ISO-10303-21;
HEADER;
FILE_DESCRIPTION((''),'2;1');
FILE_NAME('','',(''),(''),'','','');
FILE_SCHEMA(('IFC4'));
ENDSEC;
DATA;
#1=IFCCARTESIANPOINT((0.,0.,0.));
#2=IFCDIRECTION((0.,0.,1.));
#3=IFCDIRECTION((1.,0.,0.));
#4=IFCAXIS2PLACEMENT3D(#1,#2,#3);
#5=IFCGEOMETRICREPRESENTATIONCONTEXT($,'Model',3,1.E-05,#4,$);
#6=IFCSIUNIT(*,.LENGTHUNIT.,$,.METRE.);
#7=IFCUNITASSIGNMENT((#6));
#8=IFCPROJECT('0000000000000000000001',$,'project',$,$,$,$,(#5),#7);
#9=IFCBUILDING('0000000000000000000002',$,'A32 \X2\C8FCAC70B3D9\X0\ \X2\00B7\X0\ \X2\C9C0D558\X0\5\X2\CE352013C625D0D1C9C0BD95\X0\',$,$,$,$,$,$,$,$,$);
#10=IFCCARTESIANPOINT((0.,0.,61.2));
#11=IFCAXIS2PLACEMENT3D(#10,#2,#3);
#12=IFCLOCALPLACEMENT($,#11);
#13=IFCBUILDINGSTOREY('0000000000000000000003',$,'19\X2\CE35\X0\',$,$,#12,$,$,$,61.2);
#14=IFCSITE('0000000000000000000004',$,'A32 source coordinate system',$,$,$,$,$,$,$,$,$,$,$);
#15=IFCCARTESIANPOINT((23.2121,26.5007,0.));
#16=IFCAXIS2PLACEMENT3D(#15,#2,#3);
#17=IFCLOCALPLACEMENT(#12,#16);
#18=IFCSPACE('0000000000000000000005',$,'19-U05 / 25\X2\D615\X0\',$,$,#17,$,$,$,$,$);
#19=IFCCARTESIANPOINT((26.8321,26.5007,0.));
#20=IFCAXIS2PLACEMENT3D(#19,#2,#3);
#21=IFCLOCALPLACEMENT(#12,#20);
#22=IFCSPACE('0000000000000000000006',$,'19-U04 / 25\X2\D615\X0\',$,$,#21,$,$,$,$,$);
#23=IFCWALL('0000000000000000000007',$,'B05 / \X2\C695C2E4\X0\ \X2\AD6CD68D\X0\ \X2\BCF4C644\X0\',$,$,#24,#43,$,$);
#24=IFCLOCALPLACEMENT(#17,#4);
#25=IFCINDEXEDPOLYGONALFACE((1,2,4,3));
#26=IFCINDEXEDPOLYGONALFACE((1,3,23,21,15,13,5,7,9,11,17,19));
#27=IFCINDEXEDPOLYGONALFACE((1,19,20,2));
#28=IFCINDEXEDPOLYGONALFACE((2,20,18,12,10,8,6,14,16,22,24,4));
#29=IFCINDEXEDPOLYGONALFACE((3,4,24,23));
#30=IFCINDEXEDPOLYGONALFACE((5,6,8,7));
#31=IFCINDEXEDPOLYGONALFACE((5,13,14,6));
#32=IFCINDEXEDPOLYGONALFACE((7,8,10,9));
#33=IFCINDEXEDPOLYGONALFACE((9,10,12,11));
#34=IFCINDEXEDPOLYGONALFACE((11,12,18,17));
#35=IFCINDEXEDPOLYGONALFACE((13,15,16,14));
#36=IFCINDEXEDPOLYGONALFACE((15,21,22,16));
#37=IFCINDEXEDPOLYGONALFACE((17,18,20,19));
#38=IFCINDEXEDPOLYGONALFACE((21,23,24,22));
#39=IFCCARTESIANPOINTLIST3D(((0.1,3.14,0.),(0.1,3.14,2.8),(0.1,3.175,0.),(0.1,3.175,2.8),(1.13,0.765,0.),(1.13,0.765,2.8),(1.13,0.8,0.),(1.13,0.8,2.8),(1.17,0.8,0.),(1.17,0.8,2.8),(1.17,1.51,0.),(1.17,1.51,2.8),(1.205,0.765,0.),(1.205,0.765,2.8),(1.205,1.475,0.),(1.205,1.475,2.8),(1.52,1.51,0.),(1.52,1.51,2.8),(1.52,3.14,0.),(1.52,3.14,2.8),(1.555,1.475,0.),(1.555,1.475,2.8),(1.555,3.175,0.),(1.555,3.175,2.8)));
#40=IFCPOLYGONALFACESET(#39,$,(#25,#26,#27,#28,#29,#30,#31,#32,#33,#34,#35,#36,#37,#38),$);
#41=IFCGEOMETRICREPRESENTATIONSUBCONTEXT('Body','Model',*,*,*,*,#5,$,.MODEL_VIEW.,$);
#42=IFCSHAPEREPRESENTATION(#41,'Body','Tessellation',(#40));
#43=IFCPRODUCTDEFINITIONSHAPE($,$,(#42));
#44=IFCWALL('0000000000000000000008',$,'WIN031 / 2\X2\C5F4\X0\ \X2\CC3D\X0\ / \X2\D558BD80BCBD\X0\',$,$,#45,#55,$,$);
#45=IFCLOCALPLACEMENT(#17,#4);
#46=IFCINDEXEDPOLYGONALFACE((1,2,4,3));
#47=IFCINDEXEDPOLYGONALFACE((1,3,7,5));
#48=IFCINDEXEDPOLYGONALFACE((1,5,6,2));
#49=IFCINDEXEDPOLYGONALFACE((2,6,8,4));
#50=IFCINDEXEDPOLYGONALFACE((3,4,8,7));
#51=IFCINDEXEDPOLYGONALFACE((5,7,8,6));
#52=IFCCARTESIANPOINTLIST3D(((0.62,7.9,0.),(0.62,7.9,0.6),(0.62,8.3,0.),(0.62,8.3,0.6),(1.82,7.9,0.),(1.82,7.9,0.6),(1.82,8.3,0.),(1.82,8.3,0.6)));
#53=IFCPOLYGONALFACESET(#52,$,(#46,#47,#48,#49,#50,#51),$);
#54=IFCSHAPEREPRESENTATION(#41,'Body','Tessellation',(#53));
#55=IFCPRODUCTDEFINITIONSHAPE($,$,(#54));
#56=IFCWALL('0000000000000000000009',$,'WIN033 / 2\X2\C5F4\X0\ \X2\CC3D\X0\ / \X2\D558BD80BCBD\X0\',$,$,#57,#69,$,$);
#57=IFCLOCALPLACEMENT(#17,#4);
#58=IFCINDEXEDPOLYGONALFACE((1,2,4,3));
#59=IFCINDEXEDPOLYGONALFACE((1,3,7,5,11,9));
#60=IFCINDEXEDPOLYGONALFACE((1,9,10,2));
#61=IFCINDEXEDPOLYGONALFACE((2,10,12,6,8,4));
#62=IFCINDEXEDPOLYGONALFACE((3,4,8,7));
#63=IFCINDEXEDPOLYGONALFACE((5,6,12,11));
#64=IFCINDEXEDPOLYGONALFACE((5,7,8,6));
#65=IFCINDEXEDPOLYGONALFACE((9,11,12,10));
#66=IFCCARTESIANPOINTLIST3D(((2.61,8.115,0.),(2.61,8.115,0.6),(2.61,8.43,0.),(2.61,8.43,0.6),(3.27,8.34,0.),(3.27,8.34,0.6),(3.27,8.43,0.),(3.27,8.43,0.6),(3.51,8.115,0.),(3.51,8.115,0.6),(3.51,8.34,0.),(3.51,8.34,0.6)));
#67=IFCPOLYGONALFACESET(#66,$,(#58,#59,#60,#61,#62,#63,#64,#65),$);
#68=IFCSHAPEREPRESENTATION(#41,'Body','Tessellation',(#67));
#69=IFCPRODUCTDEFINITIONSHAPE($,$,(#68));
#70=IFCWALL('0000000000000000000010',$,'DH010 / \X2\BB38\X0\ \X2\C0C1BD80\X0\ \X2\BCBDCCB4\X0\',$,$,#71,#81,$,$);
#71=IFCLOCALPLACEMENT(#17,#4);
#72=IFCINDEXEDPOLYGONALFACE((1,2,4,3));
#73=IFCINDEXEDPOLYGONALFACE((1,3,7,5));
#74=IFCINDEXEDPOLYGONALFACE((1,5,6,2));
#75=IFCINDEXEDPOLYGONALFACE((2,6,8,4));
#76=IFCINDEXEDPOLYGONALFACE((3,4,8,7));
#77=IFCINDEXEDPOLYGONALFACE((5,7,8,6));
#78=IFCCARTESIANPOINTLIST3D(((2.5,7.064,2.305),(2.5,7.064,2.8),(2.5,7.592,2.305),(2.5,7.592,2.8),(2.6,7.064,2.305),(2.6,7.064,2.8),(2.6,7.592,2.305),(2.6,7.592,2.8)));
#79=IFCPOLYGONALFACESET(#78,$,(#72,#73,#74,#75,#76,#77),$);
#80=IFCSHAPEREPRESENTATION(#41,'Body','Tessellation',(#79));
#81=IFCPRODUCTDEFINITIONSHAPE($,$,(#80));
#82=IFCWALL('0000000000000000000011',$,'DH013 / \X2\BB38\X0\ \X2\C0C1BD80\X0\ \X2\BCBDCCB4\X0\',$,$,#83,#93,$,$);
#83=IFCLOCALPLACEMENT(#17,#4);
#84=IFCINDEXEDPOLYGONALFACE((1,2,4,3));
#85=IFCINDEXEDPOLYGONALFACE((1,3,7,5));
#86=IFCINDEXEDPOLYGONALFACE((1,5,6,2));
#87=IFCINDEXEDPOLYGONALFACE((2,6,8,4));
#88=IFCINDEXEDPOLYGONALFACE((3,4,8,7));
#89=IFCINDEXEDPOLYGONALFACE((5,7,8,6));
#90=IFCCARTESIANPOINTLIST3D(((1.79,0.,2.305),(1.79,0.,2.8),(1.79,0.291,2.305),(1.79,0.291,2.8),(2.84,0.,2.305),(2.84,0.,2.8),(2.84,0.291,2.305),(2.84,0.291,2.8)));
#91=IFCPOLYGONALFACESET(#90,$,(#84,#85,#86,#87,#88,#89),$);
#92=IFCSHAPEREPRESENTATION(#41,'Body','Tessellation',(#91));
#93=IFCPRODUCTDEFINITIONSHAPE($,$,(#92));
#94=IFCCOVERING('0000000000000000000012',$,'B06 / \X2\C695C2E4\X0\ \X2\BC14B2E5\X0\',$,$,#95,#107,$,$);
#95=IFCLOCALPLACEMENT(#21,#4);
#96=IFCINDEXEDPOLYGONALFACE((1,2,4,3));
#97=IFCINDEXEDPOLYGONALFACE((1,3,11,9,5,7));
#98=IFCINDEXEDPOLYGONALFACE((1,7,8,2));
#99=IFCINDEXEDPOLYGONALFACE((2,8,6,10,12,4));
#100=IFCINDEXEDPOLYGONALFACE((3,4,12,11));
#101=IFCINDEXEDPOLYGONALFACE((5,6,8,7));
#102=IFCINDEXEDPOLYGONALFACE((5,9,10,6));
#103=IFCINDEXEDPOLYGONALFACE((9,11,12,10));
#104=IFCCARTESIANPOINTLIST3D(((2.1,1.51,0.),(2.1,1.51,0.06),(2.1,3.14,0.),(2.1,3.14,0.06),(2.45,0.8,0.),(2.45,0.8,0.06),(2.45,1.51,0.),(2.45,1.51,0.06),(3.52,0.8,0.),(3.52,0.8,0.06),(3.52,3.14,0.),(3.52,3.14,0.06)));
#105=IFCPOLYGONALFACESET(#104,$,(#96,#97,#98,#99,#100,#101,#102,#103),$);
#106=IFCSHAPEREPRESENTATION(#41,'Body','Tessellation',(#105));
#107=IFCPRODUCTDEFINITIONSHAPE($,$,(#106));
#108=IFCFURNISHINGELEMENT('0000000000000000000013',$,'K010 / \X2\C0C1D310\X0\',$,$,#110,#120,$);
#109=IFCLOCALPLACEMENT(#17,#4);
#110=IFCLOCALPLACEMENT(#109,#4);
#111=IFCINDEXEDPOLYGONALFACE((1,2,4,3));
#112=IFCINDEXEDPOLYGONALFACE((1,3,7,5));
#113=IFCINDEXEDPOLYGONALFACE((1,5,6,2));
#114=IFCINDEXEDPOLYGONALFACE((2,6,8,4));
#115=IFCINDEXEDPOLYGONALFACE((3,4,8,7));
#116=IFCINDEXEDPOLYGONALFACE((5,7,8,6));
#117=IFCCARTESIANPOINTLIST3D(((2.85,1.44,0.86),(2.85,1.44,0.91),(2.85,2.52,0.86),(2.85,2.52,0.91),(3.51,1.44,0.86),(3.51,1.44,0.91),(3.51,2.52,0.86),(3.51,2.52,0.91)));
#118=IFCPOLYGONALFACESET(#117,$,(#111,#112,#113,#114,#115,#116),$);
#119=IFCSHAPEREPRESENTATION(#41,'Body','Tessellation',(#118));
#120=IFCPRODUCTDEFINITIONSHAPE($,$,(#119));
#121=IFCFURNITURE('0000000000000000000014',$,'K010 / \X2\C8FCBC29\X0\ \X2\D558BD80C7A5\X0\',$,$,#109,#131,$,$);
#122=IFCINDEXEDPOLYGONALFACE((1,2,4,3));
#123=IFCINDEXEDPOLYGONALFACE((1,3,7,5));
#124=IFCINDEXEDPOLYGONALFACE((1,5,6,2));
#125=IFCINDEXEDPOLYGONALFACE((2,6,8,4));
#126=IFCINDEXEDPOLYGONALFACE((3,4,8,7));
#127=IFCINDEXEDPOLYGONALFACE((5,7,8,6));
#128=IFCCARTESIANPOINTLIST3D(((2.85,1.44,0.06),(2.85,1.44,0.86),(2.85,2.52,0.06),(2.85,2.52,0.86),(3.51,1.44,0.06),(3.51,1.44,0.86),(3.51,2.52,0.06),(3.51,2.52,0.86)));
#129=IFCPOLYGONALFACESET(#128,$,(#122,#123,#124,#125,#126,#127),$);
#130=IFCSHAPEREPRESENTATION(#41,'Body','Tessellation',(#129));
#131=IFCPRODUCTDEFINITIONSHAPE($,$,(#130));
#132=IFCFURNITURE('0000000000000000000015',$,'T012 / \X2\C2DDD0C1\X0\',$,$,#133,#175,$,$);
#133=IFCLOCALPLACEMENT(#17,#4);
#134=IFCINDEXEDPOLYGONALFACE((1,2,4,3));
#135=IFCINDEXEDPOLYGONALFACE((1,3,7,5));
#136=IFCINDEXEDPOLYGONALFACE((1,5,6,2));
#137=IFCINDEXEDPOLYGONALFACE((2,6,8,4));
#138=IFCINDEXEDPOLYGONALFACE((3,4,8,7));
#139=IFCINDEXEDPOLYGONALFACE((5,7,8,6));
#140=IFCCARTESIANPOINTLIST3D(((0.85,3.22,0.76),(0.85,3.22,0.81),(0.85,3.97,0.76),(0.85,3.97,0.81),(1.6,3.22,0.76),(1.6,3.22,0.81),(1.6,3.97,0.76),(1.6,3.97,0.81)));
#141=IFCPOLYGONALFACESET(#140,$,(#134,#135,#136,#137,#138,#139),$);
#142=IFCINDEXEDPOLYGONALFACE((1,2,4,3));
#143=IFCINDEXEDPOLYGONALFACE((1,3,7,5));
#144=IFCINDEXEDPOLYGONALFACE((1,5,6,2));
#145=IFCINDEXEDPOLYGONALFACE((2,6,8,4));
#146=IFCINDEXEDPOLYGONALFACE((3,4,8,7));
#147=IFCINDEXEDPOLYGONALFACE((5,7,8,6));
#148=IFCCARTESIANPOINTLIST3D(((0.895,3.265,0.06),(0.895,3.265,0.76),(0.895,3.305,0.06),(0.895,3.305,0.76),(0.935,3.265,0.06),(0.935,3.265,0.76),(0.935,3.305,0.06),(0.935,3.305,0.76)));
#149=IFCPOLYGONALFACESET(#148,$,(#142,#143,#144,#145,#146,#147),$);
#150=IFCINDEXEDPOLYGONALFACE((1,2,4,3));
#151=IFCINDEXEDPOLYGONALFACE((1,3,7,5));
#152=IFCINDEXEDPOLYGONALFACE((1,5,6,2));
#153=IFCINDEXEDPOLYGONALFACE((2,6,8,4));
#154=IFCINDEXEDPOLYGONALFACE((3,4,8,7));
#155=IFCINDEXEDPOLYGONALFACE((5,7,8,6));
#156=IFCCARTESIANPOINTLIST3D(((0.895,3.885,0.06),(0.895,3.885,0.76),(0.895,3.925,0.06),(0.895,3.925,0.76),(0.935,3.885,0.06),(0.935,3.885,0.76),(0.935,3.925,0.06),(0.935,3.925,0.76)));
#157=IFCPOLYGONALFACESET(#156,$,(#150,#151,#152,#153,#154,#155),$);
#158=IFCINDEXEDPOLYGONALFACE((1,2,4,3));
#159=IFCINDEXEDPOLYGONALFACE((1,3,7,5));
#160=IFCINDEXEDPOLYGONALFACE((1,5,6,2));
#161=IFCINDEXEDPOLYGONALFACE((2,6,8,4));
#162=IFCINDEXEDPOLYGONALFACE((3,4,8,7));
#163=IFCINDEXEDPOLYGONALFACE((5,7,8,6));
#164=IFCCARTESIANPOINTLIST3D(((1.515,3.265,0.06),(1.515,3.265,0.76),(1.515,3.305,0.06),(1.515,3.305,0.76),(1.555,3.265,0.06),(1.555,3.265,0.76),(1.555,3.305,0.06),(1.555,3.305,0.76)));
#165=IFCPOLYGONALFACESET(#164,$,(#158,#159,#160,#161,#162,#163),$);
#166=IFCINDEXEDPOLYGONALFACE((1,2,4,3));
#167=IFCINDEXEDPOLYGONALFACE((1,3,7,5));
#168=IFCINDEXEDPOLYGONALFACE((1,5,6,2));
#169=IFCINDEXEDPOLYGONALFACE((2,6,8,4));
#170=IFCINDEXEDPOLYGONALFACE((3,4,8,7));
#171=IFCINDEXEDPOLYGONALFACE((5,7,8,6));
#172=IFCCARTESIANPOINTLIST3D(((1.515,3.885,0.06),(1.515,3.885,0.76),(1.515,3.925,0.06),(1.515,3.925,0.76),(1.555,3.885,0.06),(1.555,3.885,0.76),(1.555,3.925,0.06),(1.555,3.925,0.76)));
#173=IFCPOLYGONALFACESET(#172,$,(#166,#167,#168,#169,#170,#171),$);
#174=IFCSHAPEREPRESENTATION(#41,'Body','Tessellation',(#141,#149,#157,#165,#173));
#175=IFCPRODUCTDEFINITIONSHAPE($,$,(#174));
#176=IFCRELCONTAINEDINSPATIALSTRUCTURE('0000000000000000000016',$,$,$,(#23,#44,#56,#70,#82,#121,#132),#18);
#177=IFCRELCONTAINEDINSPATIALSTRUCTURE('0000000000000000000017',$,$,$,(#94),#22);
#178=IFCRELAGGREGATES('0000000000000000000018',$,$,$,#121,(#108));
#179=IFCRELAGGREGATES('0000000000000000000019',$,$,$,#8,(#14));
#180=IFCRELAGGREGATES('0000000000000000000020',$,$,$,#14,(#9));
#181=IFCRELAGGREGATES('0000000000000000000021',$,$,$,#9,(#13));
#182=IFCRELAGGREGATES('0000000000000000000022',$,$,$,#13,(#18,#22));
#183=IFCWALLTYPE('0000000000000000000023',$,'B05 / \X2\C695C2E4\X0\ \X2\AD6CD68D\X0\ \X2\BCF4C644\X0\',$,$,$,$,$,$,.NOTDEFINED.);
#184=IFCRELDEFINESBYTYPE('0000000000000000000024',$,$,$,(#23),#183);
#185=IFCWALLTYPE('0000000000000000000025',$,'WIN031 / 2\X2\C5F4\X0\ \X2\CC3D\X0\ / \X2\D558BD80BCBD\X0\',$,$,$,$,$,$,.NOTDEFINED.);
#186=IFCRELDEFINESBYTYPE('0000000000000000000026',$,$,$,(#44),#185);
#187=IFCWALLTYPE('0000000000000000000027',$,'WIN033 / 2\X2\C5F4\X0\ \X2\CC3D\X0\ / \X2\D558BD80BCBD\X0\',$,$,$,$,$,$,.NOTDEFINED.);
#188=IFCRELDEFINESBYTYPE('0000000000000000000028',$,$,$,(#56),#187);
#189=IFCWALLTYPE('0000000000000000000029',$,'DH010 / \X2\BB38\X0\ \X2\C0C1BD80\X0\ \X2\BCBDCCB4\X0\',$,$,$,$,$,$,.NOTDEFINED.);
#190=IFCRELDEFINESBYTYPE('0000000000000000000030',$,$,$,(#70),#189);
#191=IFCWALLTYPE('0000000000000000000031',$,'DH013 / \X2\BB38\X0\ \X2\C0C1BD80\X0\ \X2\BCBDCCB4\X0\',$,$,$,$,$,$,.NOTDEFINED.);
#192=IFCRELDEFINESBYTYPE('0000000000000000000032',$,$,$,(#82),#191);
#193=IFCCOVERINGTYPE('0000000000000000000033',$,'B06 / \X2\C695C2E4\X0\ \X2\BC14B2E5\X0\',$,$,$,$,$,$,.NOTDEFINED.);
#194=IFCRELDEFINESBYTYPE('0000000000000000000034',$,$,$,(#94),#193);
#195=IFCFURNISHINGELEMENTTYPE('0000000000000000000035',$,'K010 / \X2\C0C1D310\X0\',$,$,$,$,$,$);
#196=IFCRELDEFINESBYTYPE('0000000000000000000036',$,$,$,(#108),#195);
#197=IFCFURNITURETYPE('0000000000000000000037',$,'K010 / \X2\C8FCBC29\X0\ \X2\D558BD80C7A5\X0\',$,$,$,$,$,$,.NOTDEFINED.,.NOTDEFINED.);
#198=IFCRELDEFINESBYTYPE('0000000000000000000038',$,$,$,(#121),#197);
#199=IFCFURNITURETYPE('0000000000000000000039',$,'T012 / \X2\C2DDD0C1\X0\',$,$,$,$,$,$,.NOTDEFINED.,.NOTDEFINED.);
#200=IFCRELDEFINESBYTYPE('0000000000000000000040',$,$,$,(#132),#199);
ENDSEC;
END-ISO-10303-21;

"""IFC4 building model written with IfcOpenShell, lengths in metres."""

from ifc_helpers import new_model, si_unit, frame, origin, origin_with_axes, place, context, subcontext, project, spatial, polyline, outline, extrude, source, transform, mapped, type_object, type_shapes, element, aggregate, save


model = new_model("IFC4")

# Units and contexts
model_context = context("Model", 3, precision=1e-05, world=origin_with_axes())
body_context = subcontext(model_context, "Body", "Model", "MODEL_VIEW")
ifc_project = project(units=[si_unit("LENGTHUNIT", "METRE")], contexts=[model_context])

# Site, building, storey, space
site = spatial("IfcSite", under=ifc_project, Name="A32 source coordinate system")
building = spatial("IfcBuilding", under=site, Name="A32 주거동 · 지하5층–옥탑지붕")
storey_placement = place(None, frame((0.0, 0.0, 61.2), z_axis=(0.0, 0.0, 1.0), x_axis=(1.0, 0.0, 0.0)))
storey = spatial("IfcBuildingStorey", under=building, at=storey_placement, Name="19층", Elevation=61.2)
space_1_placement = place(storey_placement, frame((23.2121, 26.5007, 0.0), z_axis=(0.0, 0.0, 1.0), x_axis=(1.0, 0.0, 0.0)))
space_1 = spatial("IfcSpace", under=storey, at=space_1_placement, Name="19-U05 / 25형")

# Walls
wall_type_1 = type_object("IfcWallType", Name="B05 / 욕실 구획 보완", PredefinedType="NOTDEFINED")
shared_shape_1 = source(origin(), body_context, "Body", "SweptSolid", [
    extrude(outline(polyline([(1.17, 1.51), (1.52, 1.51), (1.52, 3.14), (0.1, 3.14), (0.1, 3.175), (1.555, 3.175), (1.555, 1.475), (1.205, 1.475), (1.205, 0.765), (1.13, 0.765), (1.13, 0.8), (1.17, 0.8), (1.17, 1.51)])), origin(), (0.0, 0.0, 1.0), 2.8),
])
type_shapes(wall_type_1, [shared_shape_1])
wall_1_placement = place(space_1_placement, origin_with_axes())
element("IfcWall", 1, at=wall_1_placement, inside=space_1, type_object=wall_type_1, Name="B05 / 욕실 구획 보완", context=body_context, shape_type="MappedRepresentation", body=[
    mapped(shared_shape_1, transform((0.0, 0.0, 0.0), scale=1.0)),
])
wall_type_2 = type_object("IfcWallType", Name="WIN031 / 2열 창 / 하부벽", PredefinedType="NOTDEFINED")
shared_shape_2 = source(origin(), body_context, "Body", "SweptSolid", [
    extrude(outline(polyline([(0.62, 8.3), (1.82, 8.3), (1.82, 7.9), (0.62, 7.9), (0.62, 8.3)])), origin(), (0.0, 0.0, 1.0), 0.6),
])
type_shapes(wall_type_2, [shared_shape_2])
wall_2_placement = place(space_1_placement, origin_with_axes())
element("IfcWall", 2, at=wall_2_placement, inside=space_1, type_object=wall_type_2, Name="WIN031 / 2열 창 / 하부벽", context=body_context, shape_type="MappedRepresentation", body=[
    mapped(shared_shape_2, transform((0.0, 0.0, 0.0), scale=1.0)),
])
wall_type_3 = type_object("IfcWallType", Name="WIN033 / 2열 창 / 하부벽", PredefinedType="NOTDEFINED")
shared_shape_3 = source(origin(), body_context, "Body", "SweptSolid", [
    extrude(outline(polyline([(2.61, 8.43), (3.27, 8.43), (3.27, 8.34), (3.51, 8.34), (3.51, 8.115), (2.61, 8.115), (2.61, 8.43)])), origin(), (0.0, 0.0, 1.0), 0.6),
])
type_shapes(wall_type_3, [shared_shape_3])
wall_3_placement = place(space_1_placement, origin_with_axes())
element("IfcWall", 3, at=wall_3_placement, inside=space_1, type_object=wall_type_3, Name="WIN033 / 2열 창 / 하부벽", context=body_context, shape_type="MappedRepresentation", body=[
    mapped(shared_shape_3, transform((0.0, 0.0, 0.0), scale=1.0)),
])
wall_type_4 = type_object("IfcWallType", Name="DH010 / 문 상부 벽체", PredefinedType="NOTDEFINED")
shared_shape_4 = source(origin(), body_context, "Body", "SweptSolid", [
    extrude(outline(polyline([(2.5, 7.592), (2.6, 7.592), (2.6, 7.064), (2.5, 7.064), (2.5, 7.592)])), frame((0.0, 0.0, 2.305)), (0.0, 0.0, 1.0), 0.495),
])
type_shapes(wall_type_4, [shared_shape_4])
wall_4_placement = place(space_1_placement, origin_with_axes())
element("IfcWall", 4, at=wall_4_placement, inside=space_1, type_object=wall_type_4, Name="DH010 / 문 상부 벽체", context=body_context, shape_type="MappedRepresentation", body=[
    mapped(shared_shape_4, transform((0.0, 0.0, 0.0), scale=1.0)),
])
wall_type_5 = type_object("IfcWallType", Name="DH013 / 문 상부 벽체", PredefinedType="NOTDEFINED")
shared_shape_5 = source(origin(), body_context, "Body", "SweptSolid", [
    extrude(outline(polyline([(2.84, 0.291), (2.84, 0.0), (1.79, 0.0), (1.79, 0.291), (2.84, 0.291)])), frame((0.0, 0.0, 2.305)), (0.0, 0.0, 1.0), 0.495),
])
type_shapes(wall_type_5, [shared_shape_5])
wall_5_placement = place(space_1_placement, origin_with_axes())
element("IfcWall", 5, at=wall_5_placement, inside=space_1, type_object=wall_type_5, Name="DH013 / 문 상부 벽체", context=body_context, shape_type="MappedRepresentation", body=[
    mapped(shared_shape_5, transform((0.0, 0.0, 0.0), scale=1.0)),
])

# Shared definitions
space_2_placement = place(storey_placement, frame((26.8321, 26.5007, 0.0), z_axis=(0.0, 0.0, 1.0), x_axis=(1.0, 0.0, 0.0)))
space_2 = spatial("IfcSpace", under=storey, at=space_2_placement, Name="19-U04 / 25형")

# Covering
covering_type = type_object("IfcCoveringType", Name="B06 / 욕실 바닥", PredefinedType="NOTDEFINED")
shared_shape_6 = source(origin(), body_context, "Body", "SweptSolid", [
    extrude(outline(polyline([(2.1, 3.14), (3.52, 3.14), (3.52, 0.8), (2.45, 0.8), (2.45, 1.51), (2.1, 1.51), (2.1, 3.14)])), origin(), (0.0, 0.0, 1.0), 0.06),
])
type_shapes(covering_type, [shared_shape_6])
covering_placement = place(space_2_placement, origin_with_axes())
element("IfcCovering", 6, at=covering_placement, inside=space_2, type_object=covering_type, Name="B06 / 욕실 바닥", context=body_context, shape_type="MappedRepresentation", body=[
    mapped(shared_shape_6, transform((0.0, 0.0, 0.0), scale=1.0)),
])

# Furnishing element
furnishing_element_type_1 = type_object("IfcFurnishingElementType", Name="K010 / 상판")
shared_shape_7 = source(origin(), body_context, "Body", "SweptSolid", [
    extrude(outline(polyline([(2.85, 2.52), (3.51, 2.52), (3.51, 1.44), (2.85, 1.44), (2.85, 2.52)])), frame((0.0, 0.0, 0.86)), (0.0, 0.0, 1.0), 0.05),
])
type_shapes(furnishing_element_type_1, [shared_shape_7])
furniture_1_placement = place(space_1_placement, origin_with_axes())
furnishing_1_placement = place(furniture_1_placement, origin_with_axes())
furnishing_1 = element("IfcFurnishingElement", 7, at=furnishing_1_placement, type_object=furnishing_element_type_1, Name="K010 / 상판", context=body_context, shape_type="MappedRepresentation", body=[
    mapped(shared_shape_7, transform((0.0, 0.0, 0.0), scale=1.0)),
])

# Furniture
furniture_type_1 = type_object("IfcFurnitureType", Name="K010 / 주방 하부장", AssemblyPlace="NOTDEFINED", PredefinedType="NOTDEFINED")
shared_shape_8 = source(origin(), body_context, "Body", "SweptSolid", [
    extrude(outline(polyline([(2.85, 1.44), (2.85, 2.52), (3.51, 2.52), (3.51, 1.44), (2.85, 1.44)])), frame((0.0, 0.0, 0.06)), (0.0, 0.0, 1.0), 0.8),
])
type_shapes(furniture_type_1, [shared_shape_8])
furniture_1 = element("IfcFurniture", 8, at=furniture_1_placement, inside=space_1, type_object=furniture_type_1, Name="K010 / 주방 하부장", context=body_context, shape_type="MappedRepresentation", body=[
    mapped(shared_shape_8, transform((0.0, 0.0, 0.0), scale=1.0)),
])
aggregate(furniture_1, [furnishing_1])
furniture_type_2 = type_object("IfcFurnitureType", Name="T012 / 식탁", AssemblyPlace="NOTDEFINED", PredefinedType="NOTDEFINED")
shared_shape_9 = source(origin(), body_context, "Body", "SweptSolid", [
    extrude(outline(polyline([(1.6, 3.97), (1.6, 3.22), (0.85, 3.22), (0.85, 3.97), (1.6, 3.97)])), frame((0.0, 0.0, 0.76)), (0.0, 0.0, 1.0), 0.05),
    extrude(outline(polyline([(0.895, 3.265), (0.895, 3.305), (0.935, 3.305), (0.935, 3.265), (0.895, 3.265)])), frame((0.0, 0.0, 0.06)), (0.0, 0.0, 1.0), 0.7),
    extrude(outline(polyline([(0.895, 3.885), (0.895, 3.925), (0.935, 3.925), (0.935, 3.885), (0.895, 3.885)])), frame((0.0, 0.0, 0.06)), (0.0, 0.0, 1.0), 0.7),
    extrude(outline(polyline([(1.515, 3.265), (1.515, 3.305), (1.555, 3.305), (1.555, 3.265), (1.515, 3.265)])), frame((0.0, 0.0, 0.06)), (0.0, 0.0, 1.0), 0.7),
    extrude(outline(polyline([(1.515, 3.885), (1.515, 3.925), (1.555, 3.925), (1.555, 3.885), (1.515, 3.885)])), frame((0.0, 0.0, 0.06)), (0.0, 0.0, 1.0), 0.7),
])
type_shapes(furniture_type_2, [shared_shape_9])
furniture_2_placement = place(space_1_placement, origin_with_axes())
element("IfcFurniture", 9, at=furniture_2_placement, inside=space_1, type_object=furniture_type_2, Name="T012 / 식탁", context=body_context, shape_type="MappedRepresentation", body=[
    mapped(shared_shape_9, transform((0.0, 0.0, 0.0), scale=1.0)),
])

save(model, "model.ifc")
